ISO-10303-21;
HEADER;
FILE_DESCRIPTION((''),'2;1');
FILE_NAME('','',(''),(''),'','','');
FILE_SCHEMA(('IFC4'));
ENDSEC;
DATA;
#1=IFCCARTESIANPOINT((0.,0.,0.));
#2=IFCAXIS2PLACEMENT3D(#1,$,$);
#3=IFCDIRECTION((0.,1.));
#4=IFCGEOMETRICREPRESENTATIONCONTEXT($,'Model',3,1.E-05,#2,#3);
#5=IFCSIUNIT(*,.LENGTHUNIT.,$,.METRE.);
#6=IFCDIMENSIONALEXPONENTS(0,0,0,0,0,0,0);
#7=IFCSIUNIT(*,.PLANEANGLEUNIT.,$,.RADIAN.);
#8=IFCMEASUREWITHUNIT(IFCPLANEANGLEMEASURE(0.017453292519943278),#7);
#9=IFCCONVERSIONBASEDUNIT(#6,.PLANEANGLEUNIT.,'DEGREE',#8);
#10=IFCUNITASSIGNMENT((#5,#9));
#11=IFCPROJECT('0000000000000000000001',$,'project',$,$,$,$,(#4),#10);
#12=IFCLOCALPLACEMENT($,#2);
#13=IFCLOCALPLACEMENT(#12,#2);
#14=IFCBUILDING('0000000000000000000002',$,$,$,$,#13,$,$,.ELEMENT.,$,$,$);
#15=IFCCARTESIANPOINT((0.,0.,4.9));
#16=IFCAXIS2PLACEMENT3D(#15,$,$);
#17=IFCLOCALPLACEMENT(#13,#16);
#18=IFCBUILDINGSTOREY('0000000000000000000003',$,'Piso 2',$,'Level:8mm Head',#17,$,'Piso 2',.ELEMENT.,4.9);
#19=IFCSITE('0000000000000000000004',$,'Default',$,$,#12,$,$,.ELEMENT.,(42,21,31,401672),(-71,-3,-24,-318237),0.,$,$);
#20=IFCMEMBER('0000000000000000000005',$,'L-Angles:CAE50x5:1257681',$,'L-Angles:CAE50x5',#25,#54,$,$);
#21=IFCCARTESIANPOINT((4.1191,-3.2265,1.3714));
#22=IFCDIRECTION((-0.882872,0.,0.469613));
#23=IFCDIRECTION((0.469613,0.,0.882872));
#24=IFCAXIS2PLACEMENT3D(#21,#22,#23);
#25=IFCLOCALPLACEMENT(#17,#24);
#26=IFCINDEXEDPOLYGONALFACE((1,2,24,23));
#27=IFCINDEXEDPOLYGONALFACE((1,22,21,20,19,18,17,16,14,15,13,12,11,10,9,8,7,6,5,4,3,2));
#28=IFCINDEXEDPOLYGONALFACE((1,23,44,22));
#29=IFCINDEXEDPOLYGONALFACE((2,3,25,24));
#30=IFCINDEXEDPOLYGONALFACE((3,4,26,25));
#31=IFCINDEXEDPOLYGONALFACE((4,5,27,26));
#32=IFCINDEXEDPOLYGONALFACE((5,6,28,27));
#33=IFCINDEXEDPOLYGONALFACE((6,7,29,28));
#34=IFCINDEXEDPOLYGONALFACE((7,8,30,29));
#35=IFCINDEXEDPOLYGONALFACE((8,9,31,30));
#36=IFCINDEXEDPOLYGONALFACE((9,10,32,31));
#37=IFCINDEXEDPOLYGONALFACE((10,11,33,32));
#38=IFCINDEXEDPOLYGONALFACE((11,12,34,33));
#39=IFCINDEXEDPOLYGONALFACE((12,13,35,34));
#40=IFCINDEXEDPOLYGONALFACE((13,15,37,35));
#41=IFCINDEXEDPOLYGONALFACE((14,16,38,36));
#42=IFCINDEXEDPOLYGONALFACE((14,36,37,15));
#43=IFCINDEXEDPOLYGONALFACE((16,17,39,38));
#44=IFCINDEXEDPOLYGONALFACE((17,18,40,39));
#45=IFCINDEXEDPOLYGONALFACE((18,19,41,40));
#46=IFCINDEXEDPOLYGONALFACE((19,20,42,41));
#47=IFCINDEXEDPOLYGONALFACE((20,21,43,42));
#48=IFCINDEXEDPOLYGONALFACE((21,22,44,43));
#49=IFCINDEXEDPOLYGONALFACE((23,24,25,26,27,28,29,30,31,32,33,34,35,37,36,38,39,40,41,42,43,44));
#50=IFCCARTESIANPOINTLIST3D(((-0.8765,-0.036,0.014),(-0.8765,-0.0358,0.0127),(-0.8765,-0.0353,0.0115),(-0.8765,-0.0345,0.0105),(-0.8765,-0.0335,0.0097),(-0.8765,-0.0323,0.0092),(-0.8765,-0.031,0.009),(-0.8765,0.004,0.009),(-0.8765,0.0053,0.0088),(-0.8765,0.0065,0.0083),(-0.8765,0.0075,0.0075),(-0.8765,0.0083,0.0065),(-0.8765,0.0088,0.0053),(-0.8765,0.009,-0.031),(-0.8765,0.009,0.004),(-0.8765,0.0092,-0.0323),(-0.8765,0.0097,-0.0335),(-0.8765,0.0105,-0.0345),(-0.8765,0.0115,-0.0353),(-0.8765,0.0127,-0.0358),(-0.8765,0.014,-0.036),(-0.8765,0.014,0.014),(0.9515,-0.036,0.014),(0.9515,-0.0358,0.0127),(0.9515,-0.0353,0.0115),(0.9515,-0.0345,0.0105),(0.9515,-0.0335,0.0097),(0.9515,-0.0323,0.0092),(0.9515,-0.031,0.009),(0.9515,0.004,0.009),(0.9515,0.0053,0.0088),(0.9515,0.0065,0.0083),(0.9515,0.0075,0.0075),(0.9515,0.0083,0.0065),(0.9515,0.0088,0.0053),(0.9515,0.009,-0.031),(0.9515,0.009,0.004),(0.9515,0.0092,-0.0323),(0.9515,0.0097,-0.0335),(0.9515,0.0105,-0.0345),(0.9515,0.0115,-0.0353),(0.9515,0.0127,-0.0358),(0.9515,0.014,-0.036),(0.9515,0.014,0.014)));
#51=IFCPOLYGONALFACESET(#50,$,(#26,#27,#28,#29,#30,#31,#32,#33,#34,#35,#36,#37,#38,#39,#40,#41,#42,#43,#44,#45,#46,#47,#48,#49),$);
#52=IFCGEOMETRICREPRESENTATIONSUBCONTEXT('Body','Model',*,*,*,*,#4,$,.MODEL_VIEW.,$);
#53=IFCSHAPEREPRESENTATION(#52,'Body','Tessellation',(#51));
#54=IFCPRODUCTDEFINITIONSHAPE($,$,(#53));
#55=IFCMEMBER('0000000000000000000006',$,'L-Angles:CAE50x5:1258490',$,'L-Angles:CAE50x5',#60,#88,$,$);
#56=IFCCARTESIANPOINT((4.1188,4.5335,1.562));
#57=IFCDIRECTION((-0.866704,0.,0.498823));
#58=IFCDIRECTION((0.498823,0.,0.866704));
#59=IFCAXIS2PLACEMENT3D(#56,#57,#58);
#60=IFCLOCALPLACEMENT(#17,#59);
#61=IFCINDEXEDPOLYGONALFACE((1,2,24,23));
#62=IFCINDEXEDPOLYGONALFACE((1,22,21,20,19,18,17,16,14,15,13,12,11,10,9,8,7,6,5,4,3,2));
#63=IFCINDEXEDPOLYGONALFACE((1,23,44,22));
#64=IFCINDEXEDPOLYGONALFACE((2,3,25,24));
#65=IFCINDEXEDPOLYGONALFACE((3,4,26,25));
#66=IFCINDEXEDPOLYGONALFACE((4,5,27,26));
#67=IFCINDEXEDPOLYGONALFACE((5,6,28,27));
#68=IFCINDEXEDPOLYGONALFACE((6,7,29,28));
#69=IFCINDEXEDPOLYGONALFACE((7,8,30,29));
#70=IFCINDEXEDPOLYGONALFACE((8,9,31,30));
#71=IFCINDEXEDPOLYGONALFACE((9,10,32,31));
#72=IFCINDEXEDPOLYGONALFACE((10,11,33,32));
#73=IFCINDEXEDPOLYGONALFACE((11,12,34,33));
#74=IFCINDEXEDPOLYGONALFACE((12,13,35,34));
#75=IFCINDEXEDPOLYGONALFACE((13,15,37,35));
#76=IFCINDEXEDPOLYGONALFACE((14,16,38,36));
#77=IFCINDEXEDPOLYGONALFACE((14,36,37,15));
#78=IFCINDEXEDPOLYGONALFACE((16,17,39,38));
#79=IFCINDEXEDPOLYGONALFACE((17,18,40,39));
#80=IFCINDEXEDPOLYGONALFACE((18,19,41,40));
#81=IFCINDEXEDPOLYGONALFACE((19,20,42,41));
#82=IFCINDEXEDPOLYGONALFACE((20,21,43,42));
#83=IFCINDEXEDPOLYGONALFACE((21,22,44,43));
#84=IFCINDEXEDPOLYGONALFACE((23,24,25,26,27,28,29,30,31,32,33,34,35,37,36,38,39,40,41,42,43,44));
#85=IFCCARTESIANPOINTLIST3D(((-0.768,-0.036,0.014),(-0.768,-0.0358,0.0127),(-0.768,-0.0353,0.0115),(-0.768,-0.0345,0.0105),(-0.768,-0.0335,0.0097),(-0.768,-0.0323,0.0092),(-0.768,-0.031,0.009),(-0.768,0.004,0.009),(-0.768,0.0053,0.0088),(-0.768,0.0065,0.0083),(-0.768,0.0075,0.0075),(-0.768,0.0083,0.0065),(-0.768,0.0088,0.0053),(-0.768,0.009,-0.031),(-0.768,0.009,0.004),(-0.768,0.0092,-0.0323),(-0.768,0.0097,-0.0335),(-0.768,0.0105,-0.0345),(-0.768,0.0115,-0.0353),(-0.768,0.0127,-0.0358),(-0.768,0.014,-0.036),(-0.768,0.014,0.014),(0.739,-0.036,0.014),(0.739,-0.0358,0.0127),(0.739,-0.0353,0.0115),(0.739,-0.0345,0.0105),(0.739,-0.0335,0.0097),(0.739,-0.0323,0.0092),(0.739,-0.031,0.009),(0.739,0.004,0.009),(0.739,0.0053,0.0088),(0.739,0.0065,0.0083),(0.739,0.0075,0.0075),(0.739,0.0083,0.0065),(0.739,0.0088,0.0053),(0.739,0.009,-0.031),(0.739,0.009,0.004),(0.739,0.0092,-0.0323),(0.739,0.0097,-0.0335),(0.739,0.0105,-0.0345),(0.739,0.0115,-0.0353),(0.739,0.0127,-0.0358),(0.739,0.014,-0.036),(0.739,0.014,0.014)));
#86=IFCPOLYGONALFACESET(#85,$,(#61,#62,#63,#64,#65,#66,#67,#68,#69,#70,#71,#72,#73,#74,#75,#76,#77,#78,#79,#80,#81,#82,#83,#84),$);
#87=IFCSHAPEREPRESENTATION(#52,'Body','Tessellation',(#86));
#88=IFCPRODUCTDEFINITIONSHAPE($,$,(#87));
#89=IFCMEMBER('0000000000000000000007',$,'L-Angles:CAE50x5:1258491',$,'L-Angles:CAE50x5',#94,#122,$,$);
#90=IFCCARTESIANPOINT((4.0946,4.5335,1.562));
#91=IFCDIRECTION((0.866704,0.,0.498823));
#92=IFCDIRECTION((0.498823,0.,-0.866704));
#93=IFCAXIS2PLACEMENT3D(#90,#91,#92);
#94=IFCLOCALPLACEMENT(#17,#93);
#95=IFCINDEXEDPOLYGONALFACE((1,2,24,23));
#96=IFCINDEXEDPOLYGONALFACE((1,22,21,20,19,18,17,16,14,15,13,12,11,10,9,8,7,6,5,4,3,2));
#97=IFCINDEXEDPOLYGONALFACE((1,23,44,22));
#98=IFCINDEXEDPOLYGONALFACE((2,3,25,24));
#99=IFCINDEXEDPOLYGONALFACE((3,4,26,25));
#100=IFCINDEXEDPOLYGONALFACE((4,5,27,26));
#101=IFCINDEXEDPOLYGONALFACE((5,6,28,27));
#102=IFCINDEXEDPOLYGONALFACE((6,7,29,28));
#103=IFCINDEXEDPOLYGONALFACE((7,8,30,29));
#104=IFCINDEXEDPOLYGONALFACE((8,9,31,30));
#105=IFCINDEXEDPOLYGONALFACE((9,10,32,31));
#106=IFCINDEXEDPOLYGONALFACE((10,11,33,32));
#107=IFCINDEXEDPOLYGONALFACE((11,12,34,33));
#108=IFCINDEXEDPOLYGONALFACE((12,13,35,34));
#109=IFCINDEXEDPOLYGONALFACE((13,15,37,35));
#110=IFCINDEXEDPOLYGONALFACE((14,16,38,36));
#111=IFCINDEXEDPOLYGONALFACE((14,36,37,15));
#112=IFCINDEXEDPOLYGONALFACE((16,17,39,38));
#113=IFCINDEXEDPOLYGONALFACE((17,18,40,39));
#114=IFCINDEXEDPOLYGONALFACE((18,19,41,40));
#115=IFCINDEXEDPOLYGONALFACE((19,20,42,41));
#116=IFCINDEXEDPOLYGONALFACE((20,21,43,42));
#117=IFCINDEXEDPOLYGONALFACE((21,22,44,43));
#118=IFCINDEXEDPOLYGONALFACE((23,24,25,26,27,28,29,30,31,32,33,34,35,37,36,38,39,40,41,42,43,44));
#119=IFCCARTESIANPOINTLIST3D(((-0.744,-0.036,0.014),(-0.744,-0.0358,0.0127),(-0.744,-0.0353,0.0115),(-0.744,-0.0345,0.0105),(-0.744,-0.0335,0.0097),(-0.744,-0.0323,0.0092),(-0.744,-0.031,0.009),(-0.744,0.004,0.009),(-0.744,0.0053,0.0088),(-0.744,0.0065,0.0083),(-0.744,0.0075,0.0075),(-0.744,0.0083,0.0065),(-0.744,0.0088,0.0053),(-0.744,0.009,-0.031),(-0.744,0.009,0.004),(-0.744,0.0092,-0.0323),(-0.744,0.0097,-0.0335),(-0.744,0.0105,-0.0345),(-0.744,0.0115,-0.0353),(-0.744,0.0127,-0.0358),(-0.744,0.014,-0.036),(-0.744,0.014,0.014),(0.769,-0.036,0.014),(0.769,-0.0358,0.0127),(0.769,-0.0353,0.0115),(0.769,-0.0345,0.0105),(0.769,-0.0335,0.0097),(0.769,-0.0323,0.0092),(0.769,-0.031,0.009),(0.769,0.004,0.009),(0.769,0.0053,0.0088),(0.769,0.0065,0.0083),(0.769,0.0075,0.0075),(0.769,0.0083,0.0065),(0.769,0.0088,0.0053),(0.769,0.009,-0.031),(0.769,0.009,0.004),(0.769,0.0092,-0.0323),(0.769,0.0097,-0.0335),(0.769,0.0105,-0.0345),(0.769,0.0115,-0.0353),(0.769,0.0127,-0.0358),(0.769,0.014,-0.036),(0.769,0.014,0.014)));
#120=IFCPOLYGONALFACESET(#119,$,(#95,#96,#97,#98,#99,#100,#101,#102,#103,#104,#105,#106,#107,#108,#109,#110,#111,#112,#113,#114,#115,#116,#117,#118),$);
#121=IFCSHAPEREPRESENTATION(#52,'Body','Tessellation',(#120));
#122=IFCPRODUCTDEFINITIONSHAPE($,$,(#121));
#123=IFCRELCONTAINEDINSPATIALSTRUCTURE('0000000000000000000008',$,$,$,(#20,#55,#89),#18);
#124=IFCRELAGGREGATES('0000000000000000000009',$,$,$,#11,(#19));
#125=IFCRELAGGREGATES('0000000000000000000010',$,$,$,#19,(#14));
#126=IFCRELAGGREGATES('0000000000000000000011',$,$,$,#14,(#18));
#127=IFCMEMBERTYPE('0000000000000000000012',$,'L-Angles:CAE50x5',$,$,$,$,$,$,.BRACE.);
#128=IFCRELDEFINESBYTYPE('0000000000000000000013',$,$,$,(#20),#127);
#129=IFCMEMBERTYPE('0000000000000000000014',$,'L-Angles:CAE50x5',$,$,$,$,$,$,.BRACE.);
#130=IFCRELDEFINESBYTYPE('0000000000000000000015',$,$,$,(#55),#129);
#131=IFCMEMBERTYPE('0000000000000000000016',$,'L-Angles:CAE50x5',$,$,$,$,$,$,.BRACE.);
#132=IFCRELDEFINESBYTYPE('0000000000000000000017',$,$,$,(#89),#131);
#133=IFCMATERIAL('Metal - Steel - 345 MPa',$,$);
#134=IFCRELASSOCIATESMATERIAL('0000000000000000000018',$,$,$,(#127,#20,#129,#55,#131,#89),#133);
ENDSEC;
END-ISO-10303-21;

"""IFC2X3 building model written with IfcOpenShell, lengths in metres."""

from ifc_helpers import new_model, entity, si_unit, converted_unit, direction, frame, frame_2d, origin, place, context, subcontext, project, spatial, polyline, circle_curve, parameter, trimmed, segment, composite_curve, outline, extrude, source, transform, mapped, material, type_object, type_shapes, element, save


model = new_model("IFC2X3")

# Units and contexts
model_context = context("Model", 3, precision=1e-05, world=origin(), true_north=direction((0.0, 1.0)))
body_context = subcontext(model_context, "Body", "Model", "MODEL_VIEW")
ifc_project = project(units=[si_unit("LENGTHUNIT", "METRE"), converted_unit("PLANEANGLEUNIT", "DEGREE", entity("IfcPlaneAngleMeasure", 0.017453292519943278), si_unit("PLANEANGLEUNIT", "RADIAN"), dimensions=[0, 0, 0, 0, 0, 0, 0])], contexts=[model_context])

# Site, building, storey
site_placement = place(None, origin())
site = spatial("IfcSite", under=ifc_project, at=site_placement, Name="Default", CompositionType="ELEMENT", RefLatitude=(42, 21, 31, 401672), RefLongitude=(-71, -3, -24, -318237), RefElevation=0.0)
building_placement = place(site_placement, origin())
building = spatial("IfcBuilding", under=site, at=building_placement, CompositionType="ELEMENT")
storey_placement = place(building_placement, frame((0.0, 0.0, 4.9)))
storey = spatial("IfcBuildingStorey", under=building, at=storey_placement, Name="Piso 2", ObjectType="Level:8mm Head", LongName="Piso 2", CompositionType="ELEMENT", Elevation=4.9)

# Shared definitions
ifc_material_1 = material(Name="Metal - Steel - 345 MPa")

# Members
member_type_1 = type_object("IfcMemberType", Name="L-Angles:CAE50x5", PredefinedType="BRACE", material=ifc_material_1)
shared_shape_1 = source(origin(), body_context, "Body", "SweptSolid", [
    extrude(outline(composite_curve([segment(polyline([(-0.0164, -0.0164), (0.0336, -0.0164)]), True, "CONTINUOUS"), segment(trimmed(circle_curve(frame_2d((0.0286, -0.0164), x_axis=(1.0, 0.0)), 0.005), [parameter(0.0)], [parameter(90.0)], True, "PARAMETER"), True, "CONTINUOUS"), segment(polyline([(0.0286, -0.0114), (-0.0064, -0.0114)]), True, "CONTINUOUS"), segment(trimmed(circle_curve(frame_2d((-0.0064, -0.0064), x_axis=(1.0, 0.0)), 0.005), [parameter(180.0)], [parameter(270.0)], True, "PARAMETER"), False, "CONTINUOUS"), segment(polyline([(-0.0114, -0.0064), (-0.0114, 0.0286)]), True, "CONTINUOUS"), segment(trimmed(circle_curve(frame_2d((-0.0164, 0.0286), x_axis=(1.0, 0.0)), 0.005), [parameter(0.0)], [parameter(90.0)], True, "PARAMETER"), True, "CONTINUOUS"), segment(polyline([(-0.0164, 0.0336), (-0.0164, -0.0164)]), True, "CONTINUOUS")], self_intersect=False)), frame((-0.8765, -0.0024, -0.0024), z_axis=(1.0, 0.0, 0.0), x_axis=(0.0, -1.0, 0.0)), (0.0, 0.0, 1.0), 1.828),
])
type_shapes(member_type_1, [shared_shape_1])
member_1_placement = place(storey_placement, frame((4.1191, -3.2265, 1.3714), z_axis=(-0.882872, 0.0, 0.469613), x_axis=(0.469613, 0.0, 0.882872)))
element("IfcMember", 1, at=member_1_placement, inside=storey, type_object=member_type_1, material=ifc_material_1, Name="L-Angles:CAE50x5:1257681", ObjectType="L-Angles:CAE50x5", context=body_context, shape_type="MappedRepresentation", body=[
    mapped(shared_shape_1, transform((0.0, 0.0, 0.0), scale=1.0)),
])
member_type_2 = type_object("IfcMemberType", Name="L-Angles:CAE50x5", PredefinedType="BRACE", material=ifc_material_1)
shared_shape_2 = source(origin(), body_context, "Body", "SweptSolid", [
    extrude(outline(composite_curve([segment(polyline([(-0.0164, -0.0164), (0.0336, -0.0164)]), True, "CONTINUOUS"), segment(trimmed(circle_curve(frame_2d((0.0286, -0.0164), x_axis=(1.0, 0.0)), 0.005), [parameter(0.0)], [parameter(90.0)], True, "PARAMETER"), True, "CONTINUOUS"), segment(polyline([(0.0286, -0.0114), (-0.0064, -0.0114)]), True, "CONTINUOUS"), segment(trimmed(circle_curve(frame_2d((-0.0064, -0.0064), x_axis=(1.0, 0.0)), 0.005), [parameter(180.0)], [parameter(270.0)], True, "PARAMETER"), False, "CONTINUOUS"), segment(polyline([(-0.0114, -0.0064), (-0.0114, 0.0286)]), True, "CONTINUOUS"), segment(trimmed(circle_curve(frame_2d((-0.0164, 0.0286), x_axis=(1.0, 0.0)), 0.005), [parameter(0.0)], [parameter(90.0)], True, "PARAMETER"), True, "CONTINUOUS"), segment(polyline([(-0.0164, 0.0336), (-0.0164, -0.0164)]), True, "CONTINUOUS")], self_intersect=False)), frame((-0.768, -0.0024, -0.0024), z_axis=(1.0, 0.0, 0.0), x_axis=(0.0, -1.0, 0.0)), (0.0, 0.0, 1.0), 1.507),
])
type_shapes(member_type_2, [shared_shape_2])
member_2_placement = place(storey_placement, frame((4.1188, 4.5335, 1.562), z_axis=(-0.866704, 0.0, 0.498823), x_axis=(0.498823, 0.0, 0.866704)))
element("IfcMember", 2, at=member_2_placement, inside=storey, type_object=member_type_2, material=ifc_material_1, Name="L-Angles:CAE50x5:1258490", ObjectType="L-Angles:CAE50x5", context=body_context, shape_type="MappedRepresentation", body=[
    mapped(shared_shape_2, transform((0.0, 0.0, 0.0), scale=1.0)),
])
member_type_3 = type_object("IfcMemberType", Name="L-Angles:CAE50x5", PredefinedType="BRACE", material=ifc_material_1)
shared_shape_3 = source(origin(), body_context, "Body", "SweptSolid", [
    extrude(outline(composite_curve([segment(polyline([(-0.0164, -0.0164), (0.0336, -0.0164)]), True, "CONTINUOUS"), segment(trimmed(circle_curve(frame_2d((0.0286, -0.0164), x_axis=(1.0, 0.0)), 0.005), [parameter(0.0)], [parameter(90.0)], True, "PARAMETER"), True, "CONTINUOUS"), segment(polyline([(0.0286, -0.0114), (-0.0064, -0.0114)]), True, "CONTINUOUS"), segment(trimmed(circle_curve(frame_2d((-0.0064, -0.0064), x_axis=(1.0, 0.0)), 0.005), [parameter(180.0)], [parameter(270.0)], True, "PARAMETER"), False, "CONTINUOUS"), segment(polyline([(-0.0114, -0.0064), (-0.0114, 0.0286)]), True, "CONTINUOUS"), segment(trimmed(circle_curve(frame_2d((-0.0164, 0.0286), x_axis=(1.0, 0.0)), 0.005), [parameter(0.0)], [parameter(90.0)], True, "PARAMETER"), True, "CONTINUOUS"), segment(polyline([(-0.0164, 0.0336), (-0.0164, -0.0164)]), True, "CONTINUOUS")], self_intersect=False)), frame((-0.744, -0.0024, -0.0024), z_axis=(1.0, 0.0, 0.0), x_axis=(0.0, -1.0, 0.0)), (0.0, 0.0, 1.0), 1.513),
])
type_shapes(member_type_3, [shared_shape_3])
member_3_placement = place(storey_placement, frame((4.0946, 4.5335, 1.562), z_axis=(0.866704, 0.0, 0.498823), x_axis=(0.498823, 0.0, -0.866704)))
element("IfcMember", 3, at=member_3_placement, inside=storey, type_object=member_type_3, material=ifc_material_1, Name="L-Angles:CAE50x5:1258491", ObjectType="L-Angles:CAE50x5", context=body_context, shape_type="MappedRepresentation", body=[
    mapped(shared_shape_3, transform((0.0, 0.0, 0.0), scale=1.0)),
])

save(model, "model.ifc")
